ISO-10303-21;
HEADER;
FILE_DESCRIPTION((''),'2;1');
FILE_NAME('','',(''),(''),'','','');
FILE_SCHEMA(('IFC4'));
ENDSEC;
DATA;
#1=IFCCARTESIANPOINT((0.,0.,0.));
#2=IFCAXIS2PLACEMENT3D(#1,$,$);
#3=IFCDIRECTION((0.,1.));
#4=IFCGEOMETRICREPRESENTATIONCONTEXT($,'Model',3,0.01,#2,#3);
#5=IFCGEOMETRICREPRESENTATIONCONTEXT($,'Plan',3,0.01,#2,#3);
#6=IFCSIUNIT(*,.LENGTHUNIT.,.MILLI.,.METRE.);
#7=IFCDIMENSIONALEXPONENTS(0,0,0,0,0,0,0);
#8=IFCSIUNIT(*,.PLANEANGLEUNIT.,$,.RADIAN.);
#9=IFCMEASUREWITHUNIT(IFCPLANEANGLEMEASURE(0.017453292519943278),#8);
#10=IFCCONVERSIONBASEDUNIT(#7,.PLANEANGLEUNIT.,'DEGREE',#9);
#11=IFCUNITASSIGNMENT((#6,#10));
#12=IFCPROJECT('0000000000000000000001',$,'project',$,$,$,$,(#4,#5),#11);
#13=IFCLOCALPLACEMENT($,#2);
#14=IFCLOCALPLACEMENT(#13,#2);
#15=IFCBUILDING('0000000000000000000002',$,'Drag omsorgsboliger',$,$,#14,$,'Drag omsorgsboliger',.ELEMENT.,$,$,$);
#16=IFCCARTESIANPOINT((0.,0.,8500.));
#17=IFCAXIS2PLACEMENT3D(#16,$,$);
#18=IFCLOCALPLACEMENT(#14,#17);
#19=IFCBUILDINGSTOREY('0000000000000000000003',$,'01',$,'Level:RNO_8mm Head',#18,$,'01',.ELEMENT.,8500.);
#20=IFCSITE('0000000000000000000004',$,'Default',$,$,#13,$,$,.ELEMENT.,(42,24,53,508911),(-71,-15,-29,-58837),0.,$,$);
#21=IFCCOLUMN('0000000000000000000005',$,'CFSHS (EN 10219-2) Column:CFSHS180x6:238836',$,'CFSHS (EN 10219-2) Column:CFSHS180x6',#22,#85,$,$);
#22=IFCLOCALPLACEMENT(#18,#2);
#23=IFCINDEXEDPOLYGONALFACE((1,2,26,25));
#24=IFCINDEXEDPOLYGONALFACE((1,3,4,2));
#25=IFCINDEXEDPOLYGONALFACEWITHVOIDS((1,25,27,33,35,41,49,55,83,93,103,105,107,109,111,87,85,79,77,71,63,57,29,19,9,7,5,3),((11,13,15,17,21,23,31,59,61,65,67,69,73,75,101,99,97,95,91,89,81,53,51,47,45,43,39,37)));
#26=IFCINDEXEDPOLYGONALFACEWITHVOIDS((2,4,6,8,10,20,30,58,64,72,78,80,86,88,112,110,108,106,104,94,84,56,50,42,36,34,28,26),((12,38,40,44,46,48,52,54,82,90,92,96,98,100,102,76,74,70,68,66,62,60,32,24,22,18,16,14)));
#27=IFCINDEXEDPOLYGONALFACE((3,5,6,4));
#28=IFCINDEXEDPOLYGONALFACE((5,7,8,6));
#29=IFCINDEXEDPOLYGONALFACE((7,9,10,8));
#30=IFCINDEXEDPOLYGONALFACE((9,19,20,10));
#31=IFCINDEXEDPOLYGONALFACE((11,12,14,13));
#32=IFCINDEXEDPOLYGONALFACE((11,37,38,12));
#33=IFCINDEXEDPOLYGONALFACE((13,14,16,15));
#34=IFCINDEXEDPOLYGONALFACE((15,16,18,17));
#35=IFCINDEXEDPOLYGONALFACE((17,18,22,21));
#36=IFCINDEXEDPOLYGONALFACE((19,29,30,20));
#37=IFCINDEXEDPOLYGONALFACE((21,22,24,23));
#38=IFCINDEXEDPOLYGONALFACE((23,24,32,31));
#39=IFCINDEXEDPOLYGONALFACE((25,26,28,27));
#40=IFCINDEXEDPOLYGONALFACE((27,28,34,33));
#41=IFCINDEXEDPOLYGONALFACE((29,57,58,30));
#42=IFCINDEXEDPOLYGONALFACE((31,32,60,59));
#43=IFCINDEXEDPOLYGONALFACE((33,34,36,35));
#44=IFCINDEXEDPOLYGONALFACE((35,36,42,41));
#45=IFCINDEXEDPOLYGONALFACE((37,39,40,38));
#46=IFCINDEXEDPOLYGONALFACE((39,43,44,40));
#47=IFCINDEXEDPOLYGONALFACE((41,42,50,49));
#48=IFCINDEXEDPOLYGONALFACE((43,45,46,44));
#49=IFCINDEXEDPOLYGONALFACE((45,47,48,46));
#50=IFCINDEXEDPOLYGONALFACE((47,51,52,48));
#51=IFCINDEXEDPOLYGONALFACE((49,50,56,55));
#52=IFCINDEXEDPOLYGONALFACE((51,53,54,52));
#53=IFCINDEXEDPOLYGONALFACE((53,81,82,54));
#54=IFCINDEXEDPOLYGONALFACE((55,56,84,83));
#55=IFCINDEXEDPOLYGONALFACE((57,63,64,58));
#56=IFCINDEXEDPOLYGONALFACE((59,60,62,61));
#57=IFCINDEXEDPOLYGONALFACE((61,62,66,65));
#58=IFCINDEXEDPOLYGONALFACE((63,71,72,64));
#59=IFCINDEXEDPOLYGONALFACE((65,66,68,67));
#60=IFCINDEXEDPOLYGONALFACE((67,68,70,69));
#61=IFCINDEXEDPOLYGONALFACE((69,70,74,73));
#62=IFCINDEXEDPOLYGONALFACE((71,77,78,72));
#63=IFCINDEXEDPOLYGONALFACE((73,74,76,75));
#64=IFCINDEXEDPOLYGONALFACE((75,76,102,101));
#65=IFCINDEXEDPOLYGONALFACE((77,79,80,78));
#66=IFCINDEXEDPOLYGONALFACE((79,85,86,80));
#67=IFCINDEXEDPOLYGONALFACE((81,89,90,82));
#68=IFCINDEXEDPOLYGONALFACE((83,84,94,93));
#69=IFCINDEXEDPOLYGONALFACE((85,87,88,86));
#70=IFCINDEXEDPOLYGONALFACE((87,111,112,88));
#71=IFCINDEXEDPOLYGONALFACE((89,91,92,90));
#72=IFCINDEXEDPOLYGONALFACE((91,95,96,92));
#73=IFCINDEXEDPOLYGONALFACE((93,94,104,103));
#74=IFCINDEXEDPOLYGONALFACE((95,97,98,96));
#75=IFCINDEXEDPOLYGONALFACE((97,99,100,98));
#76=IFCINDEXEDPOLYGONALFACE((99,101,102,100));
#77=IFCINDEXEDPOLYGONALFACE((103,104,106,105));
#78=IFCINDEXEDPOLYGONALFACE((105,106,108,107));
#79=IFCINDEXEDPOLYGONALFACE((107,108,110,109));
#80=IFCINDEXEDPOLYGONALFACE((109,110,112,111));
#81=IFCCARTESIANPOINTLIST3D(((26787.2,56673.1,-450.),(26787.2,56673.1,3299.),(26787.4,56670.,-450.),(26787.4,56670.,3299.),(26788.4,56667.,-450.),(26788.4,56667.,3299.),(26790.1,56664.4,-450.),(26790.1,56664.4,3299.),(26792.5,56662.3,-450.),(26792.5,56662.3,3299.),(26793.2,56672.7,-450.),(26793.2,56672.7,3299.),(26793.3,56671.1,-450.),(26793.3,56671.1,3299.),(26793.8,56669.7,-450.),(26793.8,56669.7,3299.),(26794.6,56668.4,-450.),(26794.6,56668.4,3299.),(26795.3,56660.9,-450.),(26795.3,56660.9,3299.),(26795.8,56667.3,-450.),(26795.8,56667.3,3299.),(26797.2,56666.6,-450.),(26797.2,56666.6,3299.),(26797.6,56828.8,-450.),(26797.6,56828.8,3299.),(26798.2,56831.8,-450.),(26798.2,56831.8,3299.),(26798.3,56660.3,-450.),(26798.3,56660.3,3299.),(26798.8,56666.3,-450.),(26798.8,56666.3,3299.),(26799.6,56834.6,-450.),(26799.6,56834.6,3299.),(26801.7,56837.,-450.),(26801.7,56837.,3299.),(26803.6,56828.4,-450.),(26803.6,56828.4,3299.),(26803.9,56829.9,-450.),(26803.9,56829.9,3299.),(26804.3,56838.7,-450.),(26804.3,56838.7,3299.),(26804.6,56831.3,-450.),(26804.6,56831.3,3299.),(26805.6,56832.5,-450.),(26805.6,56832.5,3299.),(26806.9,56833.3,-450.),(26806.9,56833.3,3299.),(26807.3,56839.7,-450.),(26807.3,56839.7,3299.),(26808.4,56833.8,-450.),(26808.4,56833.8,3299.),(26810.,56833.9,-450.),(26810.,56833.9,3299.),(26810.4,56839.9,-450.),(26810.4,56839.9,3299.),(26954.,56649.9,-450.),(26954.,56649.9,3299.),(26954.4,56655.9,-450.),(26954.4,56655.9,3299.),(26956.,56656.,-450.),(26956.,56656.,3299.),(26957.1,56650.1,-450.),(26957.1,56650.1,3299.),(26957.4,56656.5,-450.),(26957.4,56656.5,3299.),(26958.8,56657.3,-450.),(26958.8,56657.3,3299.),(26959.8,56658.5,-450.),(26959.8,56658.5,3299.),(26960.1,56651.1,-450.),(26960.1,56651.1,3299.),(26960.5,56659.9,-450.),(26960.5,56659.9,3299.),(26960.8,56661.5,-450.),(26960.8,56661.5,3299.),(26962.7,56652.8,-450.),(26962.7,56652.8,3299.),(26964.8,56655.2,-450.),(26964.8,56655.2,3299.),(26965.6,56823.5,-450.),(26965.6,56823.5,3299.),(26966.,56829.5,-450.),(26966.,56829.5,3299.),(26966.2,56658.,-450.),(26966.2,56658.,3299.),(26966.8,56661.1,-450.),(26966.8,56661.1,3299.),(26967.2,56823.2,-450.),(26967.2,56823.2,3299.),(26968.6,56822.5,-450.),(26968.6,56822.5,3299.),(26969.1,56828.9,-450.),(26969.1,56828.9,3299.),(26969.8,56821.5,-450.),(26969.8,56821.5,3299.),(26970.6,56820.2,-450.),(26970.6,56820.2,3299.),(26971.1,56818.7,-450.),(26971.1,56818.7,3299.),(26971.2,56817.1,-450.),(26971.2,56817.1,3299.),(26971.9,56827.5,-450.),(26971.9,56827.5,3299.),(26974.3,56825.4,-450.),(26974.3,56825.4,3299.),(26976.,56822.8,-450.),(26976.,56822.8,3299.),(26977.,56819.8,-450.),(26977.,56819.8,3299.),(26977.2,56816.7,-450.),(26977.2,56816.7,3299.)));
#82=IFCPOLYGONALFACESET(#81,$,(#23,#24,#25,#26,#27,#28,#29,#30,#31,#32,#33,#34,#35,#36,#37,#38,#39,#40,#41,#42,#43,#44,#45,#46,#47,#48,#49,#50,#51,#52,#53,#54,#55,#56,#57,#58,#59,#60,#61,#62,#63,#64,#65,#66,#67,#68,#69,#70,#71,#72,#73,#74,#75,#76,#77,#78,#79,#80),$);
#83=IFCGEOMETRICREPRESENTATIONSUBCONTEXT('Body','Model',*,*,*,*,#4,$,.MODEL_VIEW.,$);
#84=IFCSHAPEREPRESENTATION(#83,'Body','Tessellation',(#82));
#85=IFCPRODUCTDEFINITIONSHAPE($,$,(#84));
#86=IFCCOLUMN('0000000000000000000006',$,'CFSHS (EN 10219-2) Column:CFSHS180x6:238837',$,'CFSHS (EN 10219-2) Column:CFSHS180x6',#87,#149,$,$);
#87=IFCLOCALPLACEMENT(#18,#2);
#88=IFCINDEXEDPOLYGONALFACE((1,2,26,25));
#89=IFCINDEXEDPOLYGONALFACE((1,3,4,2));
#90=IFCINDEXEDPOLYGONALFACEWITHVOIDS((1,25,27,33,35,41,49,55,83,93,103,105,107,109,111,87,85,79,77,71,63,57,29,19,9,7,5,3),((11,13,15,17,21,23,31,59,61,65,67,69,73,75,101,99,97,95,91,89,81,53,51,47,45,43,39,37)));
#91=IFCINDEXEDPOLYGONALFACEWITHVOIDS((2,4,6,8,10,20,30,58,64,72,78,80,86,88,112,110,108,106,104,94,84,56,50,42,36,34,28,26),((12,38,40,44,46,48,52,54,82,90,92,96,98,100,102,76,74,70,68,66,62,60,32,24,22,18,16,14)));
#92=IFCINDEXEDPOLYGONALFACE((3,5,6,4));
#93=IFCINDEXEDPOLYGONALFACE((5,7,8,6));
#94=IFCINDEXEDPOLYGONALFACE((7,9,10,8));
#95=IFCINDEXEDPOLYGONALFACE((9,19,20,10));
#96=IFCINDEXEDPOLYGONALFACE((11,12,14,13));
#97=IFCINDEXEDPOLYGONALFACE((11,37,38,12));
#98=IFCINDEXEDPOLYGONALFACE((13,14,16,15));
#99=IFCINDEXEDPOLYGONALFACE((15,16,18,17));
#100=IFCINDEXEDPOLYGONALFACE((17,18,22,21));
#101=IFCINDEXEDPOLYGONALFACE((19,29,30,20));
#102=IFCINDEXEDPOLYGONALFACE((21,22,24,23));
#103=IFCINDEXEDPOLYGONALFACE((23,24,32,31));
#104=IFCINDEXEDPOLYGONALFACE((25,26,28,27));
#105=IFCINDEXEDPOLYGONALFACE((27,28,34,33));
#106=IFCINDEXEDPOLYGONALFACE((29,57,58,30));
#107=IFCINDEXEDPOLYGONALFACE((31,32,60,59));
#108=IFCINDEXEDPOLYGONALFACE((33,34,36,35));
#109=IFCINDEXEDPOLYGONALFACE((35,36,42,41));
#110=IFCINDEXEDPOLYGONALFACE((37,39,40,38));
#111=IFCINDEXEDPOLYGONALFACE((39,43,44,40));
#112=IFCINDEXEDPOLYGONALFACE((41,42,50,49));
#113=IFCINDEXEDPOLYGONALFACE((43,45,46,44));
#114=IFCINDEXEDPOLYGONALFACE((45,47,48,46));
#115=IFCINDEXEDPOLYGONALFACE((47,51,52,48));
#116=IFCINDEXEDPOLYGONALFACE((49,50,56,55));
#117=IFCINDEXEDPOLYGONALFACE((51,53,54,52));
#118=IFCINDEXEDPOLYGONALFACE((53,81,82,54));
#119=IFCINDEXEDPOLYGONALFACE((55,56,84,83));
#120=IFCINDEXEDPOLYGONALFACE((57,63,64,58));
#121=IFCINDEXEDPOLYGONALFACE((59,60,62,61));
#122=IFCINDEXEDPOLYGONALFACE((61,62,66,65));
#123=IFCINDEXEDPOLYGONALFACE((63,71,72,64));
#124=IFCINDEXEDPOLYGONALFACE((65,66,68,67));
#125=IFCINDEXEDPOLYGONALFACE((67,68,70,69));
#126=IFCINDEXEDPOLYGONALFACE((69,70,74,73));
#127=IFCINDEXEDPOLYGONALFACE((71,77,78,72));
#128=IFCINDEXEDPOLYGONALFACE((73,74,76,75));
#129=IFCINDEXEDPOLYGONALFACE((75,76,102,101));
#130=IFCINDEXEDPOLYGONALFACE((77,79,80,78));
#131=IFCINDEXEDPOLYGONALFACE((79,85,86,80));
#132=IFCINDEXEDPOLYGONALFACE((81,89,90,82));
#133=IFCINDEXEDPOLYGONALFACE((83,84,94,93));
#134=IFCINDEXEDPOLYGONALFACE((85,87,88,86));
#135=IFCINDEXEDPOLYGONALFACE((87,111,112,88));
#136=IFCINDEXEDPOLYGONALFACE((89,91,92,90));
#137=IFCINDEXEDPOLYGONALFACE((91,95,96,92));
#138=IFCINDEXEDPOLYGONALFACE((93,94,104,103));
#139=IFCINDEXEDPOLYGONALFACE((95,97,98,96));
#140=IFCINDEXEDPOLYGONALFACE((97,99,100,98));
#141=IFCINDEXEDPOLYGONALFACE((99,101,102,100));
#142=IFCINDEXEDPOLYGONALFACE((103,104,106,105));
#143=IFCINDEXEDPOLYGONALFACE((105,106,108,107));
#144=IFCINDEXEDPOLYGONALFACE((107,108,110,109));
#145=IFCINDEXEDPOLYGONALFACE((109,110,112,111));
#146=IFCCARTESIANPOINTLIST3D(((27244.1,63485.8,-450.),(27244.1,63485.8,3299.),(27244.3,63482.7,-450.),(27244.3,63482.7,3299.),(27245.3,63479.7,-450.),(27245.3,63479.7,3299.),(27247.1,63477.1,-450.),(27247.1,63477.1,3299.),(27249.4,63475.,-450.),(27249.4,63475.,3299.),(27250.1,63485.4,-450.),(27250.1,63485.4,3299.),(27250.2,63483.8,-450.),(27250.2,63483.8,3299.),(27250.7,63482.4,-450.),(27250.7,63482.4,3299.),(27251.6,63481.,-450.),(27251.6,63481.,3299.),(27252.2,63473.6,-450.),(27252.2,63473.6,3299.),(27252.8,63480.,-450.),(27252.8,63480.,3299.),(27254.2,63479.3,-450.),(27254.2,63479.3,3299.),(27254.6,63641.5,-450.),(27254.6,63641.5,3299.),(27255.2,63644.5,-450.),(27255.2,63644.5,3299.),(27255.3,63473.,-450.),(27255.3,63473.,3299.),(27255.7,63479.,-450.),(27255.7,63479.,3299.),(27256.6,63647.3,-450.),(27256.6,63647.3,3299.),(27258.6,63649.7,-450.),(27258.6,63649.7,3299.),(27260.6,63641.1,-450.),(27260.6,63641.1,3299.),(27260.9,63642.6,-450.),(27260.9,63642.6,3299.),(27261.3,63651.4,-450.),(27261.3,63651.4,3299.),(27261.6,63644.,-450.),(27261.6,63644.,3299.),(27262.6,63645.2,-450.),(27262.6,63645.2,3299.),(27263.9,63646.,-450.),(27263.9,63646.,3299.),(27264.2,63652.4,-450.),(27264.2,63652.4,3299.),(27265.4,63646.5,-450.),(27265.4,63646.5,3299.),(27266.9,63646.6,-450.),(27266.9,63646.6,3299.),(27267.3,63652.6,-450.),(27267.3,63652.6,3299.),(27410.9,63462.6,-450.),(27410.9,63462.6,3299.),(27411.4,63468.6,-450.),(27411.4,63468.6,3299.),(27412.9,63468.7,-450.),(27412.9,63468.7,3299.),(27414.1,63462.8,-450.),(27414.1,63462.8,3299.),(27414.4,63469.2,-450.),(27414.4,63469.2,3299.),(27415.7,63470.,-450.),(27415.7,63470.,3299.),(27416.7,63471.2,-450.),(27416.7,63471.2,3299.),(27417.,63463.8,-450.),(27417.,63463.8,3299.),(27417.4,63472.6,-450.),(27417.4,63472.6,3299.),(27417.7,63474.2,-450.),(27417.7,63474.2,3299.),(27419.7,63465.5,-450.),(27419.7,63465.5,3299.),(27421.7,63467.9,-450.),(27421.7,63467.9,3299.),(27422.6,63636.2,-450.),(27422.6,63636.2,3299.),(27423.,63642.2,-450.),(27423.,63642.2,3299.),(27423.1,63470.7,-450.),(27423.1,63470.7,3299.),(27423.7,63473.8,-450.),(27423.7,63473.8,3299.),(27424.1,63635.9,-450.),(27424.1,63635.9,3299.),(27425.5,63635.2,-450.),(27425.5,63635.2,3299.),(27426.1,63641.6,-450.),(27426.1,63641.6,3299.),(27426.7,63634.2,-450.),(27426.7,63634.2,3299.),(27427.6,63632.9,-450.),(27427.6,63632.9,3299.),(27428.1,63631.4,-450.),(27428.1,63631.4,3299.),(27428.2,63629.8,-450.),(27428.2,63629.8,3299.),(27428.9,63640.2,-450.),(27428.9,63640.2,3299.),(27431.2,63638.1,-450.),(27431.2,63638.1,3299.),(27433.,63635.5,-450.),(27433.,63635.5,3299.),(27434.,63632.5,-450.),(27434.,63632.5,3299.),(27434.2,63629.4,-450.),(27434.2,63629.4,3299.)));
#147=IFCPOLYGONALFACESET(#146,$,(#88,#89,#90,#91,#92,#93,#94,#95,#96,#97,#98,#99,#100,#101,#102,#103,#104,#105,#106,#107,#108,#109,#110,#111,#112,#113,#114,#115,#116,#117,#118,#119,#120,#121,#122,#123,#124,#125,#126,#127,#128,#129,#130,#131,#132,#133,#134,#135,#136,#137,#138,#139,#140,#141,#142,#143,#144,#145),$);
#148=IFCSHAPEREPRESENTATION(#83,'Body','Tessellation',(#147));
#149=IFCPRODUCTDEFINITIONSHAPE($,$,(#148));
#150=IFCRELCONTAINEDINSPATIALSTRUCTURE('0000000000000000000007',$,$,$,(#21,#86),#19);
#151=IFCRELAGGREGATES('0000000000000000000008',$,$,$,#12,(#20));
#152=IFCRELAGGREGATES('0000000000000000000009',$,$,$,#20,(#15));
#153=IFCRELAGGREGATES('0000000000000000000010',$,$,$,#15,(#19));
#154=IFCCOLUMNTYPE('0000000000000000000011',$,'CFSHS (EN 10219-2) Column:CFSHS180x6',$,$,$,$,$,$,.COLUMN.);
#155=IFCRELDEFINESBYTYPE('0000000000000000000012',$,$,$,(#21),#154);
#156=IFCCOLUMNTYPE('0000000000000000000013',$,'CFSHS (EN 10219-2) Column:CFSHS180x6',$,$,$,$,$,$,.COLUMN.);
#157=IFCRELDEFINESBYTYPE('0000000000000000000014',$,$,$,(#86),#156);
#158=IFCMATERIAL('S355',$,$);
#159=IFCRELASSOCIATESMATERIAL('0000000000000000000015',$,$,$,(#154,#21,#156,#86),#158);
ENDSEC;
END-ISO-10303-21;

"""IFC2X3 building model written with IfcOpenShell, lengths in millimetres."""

from ifc_helpers import new_model, entity, si_unit, converted_unit, direction, frame, frame_2d, origin, place, context, subcontext, project, spatial, polyline, circle_curve, parameter, trimmed, segment, composite_curve, outline, extrude, source, transform, mapped, material, type_object, type_shapes, element, save


model = new_model("IFC2X3")

# Units and contexts
model_context = context("Model", 3, precision=0.01, world=origin(), true_north=direction((0.0, 1.0)))
plan_context = context("Plan", 3, precision=0.01, world=origin(), true_north=direction((0.0, 1.0)))
body_context = subcontext(model_context, "Body", "Model", "MODEL_VIEW")
ifc_project = project(units=[si_unit("LENGTHUNIT", "METRE", prefix="MILLI"), converted_unit("PLANEANGLEUNIT", "DEGREE", entity("IfcPlaneAngleMeasure", 0.017453292519943278), si_unit("PLANEANGLEUNIT", "RADIAN"), dimensions=[0, 0, 0, 0, 0, 0, 0])], contexts=[model_context, plan_context])

# Site, building, storey
site_placement = place(None, origin())
site = spatial("IfcSite", under=ifc_project, at=site_placement, Name="Default", CompositionType="ELEMENT", RefLatitude=(42, 24, 53, 508911), RefLongitude=(-71, -15, -29, -58837), RefElevation=0.0)
building_placement = place(site_placement, origin())
building = spatial("IfcBuilding", under=site, at=building_placement, Name="Drag omsorgsboliger", LongName="Drag omsorgsboliger", CompositionType="ELEMENT")
storey_placement = place(building_placement, frame((0.0, 0.0, 8500.0)))
storey = spatial("IfcBuildingStorey", under=building, at=storey_placement, Name="01", ObjectType="Level:RNO_8mm Head", LongName="01", CompositionType="ELEMENT", Elevation=8500.0)

# Columns
ifc_material = material(Name="S355")
column_type_1 = type_object("IfcColumnType", Name="CFSHS (EN 10219-2) Column:CFSHS180x6", PredefinedType="COLUMN", material=ifc_material)
shared_shape_1 = source(origin(), body_context, "Body", "SweptSolid", [
    extrude(outline(composite_curve([segment(polyline([(-78.0, -90.0), (78.0, -90.0)]), True, "CONTINUOUS"), segment(trimmed(circle_curve(frame_2d((78.0, -78.0), x_axis=(-1.0, 0.0)), 12.0), [parameter(90.0)], [parameter(180.0)], True, "PARAMETER"), True, "CONTINUOUS"), segment(polyline([(90.0, -78.0), (90.0, 78.0)]), True, "CONTINUOUS"), segment(trimmed(circle_curve(frame_2d((78.0, 78.0), x_axis=(-1.0, 0.0)), 12.0), [parameter(180.0)], [parameter(270.0)], True, "PARAMETER"), True, "CONTINUOUS"), segment(polyline([(78.0, 90.0), (-78.0, 90.0)]), True, "CONTINUOUS"), segment(trimmed(circle_curve(frame_2d((-78.0, 78.0), x_axis=(-1.0, 0.0)), 12.0), [parameter(270.0)], [parameter(360.0)], True, "PARAMETER"), True, "CONTINUOUS"), segment(polyline([(-90.0, 78.0), (-90.0, -78.0)]), True, "CONTINUOUS"), segment(trimmed(circle_curve(frame_2d((-78.0, -78.0), x_axis=(-1.0, 0.0)), 12.0), [parameter(360.0)], [parameter(90.0)], True, "PARAMETER"), True, "CONTINUOUS")], self_intersect=False), holes=[composite_curve([segment(trimmed(circle_curve(frame_2d((-78.0, -78.0), x_axis=(-1.0, 0.0)), 6.0), [parameter(360.0)], [parameter(90.0)], True, "PARAMETER"), False, "CONTINUOUS"), segment(polyline([(-84.0, -78.0), (-84.0, 78.0)]), True, "CONTINUOUS"), segment(trimmed(circle_curve(frame_2d((-78.0, 78.0), x_axis=(-1.0, 0.0)), 6.0), [parameter(270.0)], [parameter(360.0)], True, "PARAMETER"), False, "CONTINUOUS"), segment(polyline([(-78.0, 84.0), (78.0, 84.0)]), True, "CONTINUOUS"), segment(trimmed(circle_curve(frame_2d((78.0, 78.0), x_axis=(-1.0, 0.0)), 6.0), [parameter(180.0)], [parameter(270.0)], True, "PARAMETER"), False, "CONTINUOUS"), segment(polyline([(84.0, 78.0), (84.0, -78.0)]), True, "CONTINUOUS"), segment(trimmed(circle_curve(frame_2d((78.0, -78.0), x_axis=(-1.0, 0.0)), 6.0), [parameter(90.0)], [parameter(180.0)], True, "PARAMETER"), False, "CONTINUOUS"), segment(polyline([(78.0, -84.0), (-78.0, -84.0)]), True, "CONTINUOUS")], self_intersect=False)]), frame((26882.2, 56744.9, 8050.0), z_axis=(0.0, 0.0, 1.0), x_axis=(-0.997758, 0.066923, 0.0)), (0.0, 0.0, 1.0), 3749.0),
])
type_shapes(column_type_1, [shared_shape_1])
column_1_placement = place(storey_placement, frame((0.0, 0.0, -8500.0)))
element("IfcColumn", 1, at=column_1_placement, inside=storey, type_object=column_type_1, material=ifc_material, Name="CFSHS (EN 10219-2) Column:CFSHS180x6:238836", ObjectType="CFSHS (EN 10219-2) Column:CFSHS180x6", context=body_context, shape_type="MappedRepresentation", body=[
    mapped(shared_shape_1, transform((0.0, 0.0, 0.0), scale=1.0)),
])
column_type_2 = type_object("IfcColumnType", Name="CFSHS (EN 10219-2) Column:CFSHS180x6", PredefinedType="COLUMN", material=ifc_material)
shared_shape_2 = source(origin(), body_context, "Body", "SweptSolid", [
    extrude(outline(composite_curve([segment(polyline([(-78.0, -90.0), (78.0, -90.0)]), True, "CONTINUOUS"), segment(trimmed(circle_curve(frame_2d((78.0, -78.0), x_axis=(-1.0, 0.0)), 12.0), [parameter(90.0)], [parameter(180.0)], True, "PARAMETER"), True, "CONTINUOUS"), segment(polyline([(90.0, -78.0), (90.0, 78.0)]), True, "CONTINUOUS"), segment(trimmed(circle_curve(frame_2d((78.0, 78.0), x_axis=(-1.0, 0.0)), 12.0), [parameter(180.0)], [parameter(270.0)], True, "PARAMETER"), True, "CONTINUOUS"), segment(polyline([(78.0, 90.0), (-78.0, 90.0)]), True, "CONTINUOUS"), segment(trimmed(circle_curve(frame_2d((-78.0, 78.0), x_axis=(-1.0, 0.0)), 12.0), [parameter(270.0)], [parameter(360.0)], True, "PARAMETER"), True, "CONTINUOUS"), segment(polyline([(-90.0, 78.0), (-90.0, -78.0)]), True, "CONTINUOUS"), segment(trimmed(circle_curve(frame_2d((-78.0, -78.0), x_axis=(-1.0, 0.0)), 12.0), [parameter(360.0)], [parameter(90.0)], True, "PARAMETER"), True, "CONTINUOUS")], self_intersect=False), holes=[composite_curve([segment(trimmed(circle_curve(frame_2d((-78.0, -78.0), x_axis=(-1.0, 0.0)), 6.0), [parameter(360.0)], [parameter(90.0)], True, "PARAMETER"), False, "CONTINUOUS"), segment(polyline([(-84.0, -78.0), (-84.0, 78.0)]), True, "CONTINUOUS"), segment(trimmed(circle_curve(frame_2d((-78.0, 78.0), x_axis=(-1.0, 0.0)), 6.0), [parameter(270.0)], [parameter(360.0)], True, "PARAMETER"), False, "CONTINUOUS"), segment(polyline([(-78.0, 84.0), (78.0, 84.0)]), True, "CONTINUOUS"), segment(trimmed(circle_curve(frame_2d((78.0, 78.0), x_axis=(-1.0, 0.0)), 6.0), [parameter(180.0)], [parameter(270.0)], True, "PARAMETER"), False, "CONTINUOUS"), segment(polyline([(84.0, 78.0), (84.0, -78.0)]), True, "CONTINUOUS"), segment(trimmed(circle_curve(frame_2d((78.0, -78.0), x_axis=(-1.0, 0.0)), 6.0), [parameter(90.0)], [parameter(180.0)], True, "PARAMETER"), False, "CONTINUOUS"), segment(polyline([(78.0, -84.0), (-78.0, -84.0)]), True, "CONTINUOUS")], self_intersect=False)]), frame((27339.1, 63557.6, 8050.0), z_axis=(0.0, 0.0, 1.0), x_axis=(-0.997758, 0.066923, 0.0)), (0.0, 0.0, 1.0), 3749.0),
])
type_shapes(column_type_2, [shared_shape_2])
column_2_placement = place(storey_placement, frame((0.0, 0.0, -8500.0)))
element("IfcColumn", 2, at=column_2_placement, inside=storey, type_object=column_type_2, material=ifc_material, Name="CFSHS (EN 10219-2) Column:CFSHS180x6:238837", ObjectType="CFSHS (EN 10219-2) Column:CFSHS180x6", context=body_context, shape_type="MappedRepresentation", body=[
    mapped(shared_shape_2, transform((0.0, 0.0, 0.0), scale=1.0)),
])

save(model, "model.ifc")
